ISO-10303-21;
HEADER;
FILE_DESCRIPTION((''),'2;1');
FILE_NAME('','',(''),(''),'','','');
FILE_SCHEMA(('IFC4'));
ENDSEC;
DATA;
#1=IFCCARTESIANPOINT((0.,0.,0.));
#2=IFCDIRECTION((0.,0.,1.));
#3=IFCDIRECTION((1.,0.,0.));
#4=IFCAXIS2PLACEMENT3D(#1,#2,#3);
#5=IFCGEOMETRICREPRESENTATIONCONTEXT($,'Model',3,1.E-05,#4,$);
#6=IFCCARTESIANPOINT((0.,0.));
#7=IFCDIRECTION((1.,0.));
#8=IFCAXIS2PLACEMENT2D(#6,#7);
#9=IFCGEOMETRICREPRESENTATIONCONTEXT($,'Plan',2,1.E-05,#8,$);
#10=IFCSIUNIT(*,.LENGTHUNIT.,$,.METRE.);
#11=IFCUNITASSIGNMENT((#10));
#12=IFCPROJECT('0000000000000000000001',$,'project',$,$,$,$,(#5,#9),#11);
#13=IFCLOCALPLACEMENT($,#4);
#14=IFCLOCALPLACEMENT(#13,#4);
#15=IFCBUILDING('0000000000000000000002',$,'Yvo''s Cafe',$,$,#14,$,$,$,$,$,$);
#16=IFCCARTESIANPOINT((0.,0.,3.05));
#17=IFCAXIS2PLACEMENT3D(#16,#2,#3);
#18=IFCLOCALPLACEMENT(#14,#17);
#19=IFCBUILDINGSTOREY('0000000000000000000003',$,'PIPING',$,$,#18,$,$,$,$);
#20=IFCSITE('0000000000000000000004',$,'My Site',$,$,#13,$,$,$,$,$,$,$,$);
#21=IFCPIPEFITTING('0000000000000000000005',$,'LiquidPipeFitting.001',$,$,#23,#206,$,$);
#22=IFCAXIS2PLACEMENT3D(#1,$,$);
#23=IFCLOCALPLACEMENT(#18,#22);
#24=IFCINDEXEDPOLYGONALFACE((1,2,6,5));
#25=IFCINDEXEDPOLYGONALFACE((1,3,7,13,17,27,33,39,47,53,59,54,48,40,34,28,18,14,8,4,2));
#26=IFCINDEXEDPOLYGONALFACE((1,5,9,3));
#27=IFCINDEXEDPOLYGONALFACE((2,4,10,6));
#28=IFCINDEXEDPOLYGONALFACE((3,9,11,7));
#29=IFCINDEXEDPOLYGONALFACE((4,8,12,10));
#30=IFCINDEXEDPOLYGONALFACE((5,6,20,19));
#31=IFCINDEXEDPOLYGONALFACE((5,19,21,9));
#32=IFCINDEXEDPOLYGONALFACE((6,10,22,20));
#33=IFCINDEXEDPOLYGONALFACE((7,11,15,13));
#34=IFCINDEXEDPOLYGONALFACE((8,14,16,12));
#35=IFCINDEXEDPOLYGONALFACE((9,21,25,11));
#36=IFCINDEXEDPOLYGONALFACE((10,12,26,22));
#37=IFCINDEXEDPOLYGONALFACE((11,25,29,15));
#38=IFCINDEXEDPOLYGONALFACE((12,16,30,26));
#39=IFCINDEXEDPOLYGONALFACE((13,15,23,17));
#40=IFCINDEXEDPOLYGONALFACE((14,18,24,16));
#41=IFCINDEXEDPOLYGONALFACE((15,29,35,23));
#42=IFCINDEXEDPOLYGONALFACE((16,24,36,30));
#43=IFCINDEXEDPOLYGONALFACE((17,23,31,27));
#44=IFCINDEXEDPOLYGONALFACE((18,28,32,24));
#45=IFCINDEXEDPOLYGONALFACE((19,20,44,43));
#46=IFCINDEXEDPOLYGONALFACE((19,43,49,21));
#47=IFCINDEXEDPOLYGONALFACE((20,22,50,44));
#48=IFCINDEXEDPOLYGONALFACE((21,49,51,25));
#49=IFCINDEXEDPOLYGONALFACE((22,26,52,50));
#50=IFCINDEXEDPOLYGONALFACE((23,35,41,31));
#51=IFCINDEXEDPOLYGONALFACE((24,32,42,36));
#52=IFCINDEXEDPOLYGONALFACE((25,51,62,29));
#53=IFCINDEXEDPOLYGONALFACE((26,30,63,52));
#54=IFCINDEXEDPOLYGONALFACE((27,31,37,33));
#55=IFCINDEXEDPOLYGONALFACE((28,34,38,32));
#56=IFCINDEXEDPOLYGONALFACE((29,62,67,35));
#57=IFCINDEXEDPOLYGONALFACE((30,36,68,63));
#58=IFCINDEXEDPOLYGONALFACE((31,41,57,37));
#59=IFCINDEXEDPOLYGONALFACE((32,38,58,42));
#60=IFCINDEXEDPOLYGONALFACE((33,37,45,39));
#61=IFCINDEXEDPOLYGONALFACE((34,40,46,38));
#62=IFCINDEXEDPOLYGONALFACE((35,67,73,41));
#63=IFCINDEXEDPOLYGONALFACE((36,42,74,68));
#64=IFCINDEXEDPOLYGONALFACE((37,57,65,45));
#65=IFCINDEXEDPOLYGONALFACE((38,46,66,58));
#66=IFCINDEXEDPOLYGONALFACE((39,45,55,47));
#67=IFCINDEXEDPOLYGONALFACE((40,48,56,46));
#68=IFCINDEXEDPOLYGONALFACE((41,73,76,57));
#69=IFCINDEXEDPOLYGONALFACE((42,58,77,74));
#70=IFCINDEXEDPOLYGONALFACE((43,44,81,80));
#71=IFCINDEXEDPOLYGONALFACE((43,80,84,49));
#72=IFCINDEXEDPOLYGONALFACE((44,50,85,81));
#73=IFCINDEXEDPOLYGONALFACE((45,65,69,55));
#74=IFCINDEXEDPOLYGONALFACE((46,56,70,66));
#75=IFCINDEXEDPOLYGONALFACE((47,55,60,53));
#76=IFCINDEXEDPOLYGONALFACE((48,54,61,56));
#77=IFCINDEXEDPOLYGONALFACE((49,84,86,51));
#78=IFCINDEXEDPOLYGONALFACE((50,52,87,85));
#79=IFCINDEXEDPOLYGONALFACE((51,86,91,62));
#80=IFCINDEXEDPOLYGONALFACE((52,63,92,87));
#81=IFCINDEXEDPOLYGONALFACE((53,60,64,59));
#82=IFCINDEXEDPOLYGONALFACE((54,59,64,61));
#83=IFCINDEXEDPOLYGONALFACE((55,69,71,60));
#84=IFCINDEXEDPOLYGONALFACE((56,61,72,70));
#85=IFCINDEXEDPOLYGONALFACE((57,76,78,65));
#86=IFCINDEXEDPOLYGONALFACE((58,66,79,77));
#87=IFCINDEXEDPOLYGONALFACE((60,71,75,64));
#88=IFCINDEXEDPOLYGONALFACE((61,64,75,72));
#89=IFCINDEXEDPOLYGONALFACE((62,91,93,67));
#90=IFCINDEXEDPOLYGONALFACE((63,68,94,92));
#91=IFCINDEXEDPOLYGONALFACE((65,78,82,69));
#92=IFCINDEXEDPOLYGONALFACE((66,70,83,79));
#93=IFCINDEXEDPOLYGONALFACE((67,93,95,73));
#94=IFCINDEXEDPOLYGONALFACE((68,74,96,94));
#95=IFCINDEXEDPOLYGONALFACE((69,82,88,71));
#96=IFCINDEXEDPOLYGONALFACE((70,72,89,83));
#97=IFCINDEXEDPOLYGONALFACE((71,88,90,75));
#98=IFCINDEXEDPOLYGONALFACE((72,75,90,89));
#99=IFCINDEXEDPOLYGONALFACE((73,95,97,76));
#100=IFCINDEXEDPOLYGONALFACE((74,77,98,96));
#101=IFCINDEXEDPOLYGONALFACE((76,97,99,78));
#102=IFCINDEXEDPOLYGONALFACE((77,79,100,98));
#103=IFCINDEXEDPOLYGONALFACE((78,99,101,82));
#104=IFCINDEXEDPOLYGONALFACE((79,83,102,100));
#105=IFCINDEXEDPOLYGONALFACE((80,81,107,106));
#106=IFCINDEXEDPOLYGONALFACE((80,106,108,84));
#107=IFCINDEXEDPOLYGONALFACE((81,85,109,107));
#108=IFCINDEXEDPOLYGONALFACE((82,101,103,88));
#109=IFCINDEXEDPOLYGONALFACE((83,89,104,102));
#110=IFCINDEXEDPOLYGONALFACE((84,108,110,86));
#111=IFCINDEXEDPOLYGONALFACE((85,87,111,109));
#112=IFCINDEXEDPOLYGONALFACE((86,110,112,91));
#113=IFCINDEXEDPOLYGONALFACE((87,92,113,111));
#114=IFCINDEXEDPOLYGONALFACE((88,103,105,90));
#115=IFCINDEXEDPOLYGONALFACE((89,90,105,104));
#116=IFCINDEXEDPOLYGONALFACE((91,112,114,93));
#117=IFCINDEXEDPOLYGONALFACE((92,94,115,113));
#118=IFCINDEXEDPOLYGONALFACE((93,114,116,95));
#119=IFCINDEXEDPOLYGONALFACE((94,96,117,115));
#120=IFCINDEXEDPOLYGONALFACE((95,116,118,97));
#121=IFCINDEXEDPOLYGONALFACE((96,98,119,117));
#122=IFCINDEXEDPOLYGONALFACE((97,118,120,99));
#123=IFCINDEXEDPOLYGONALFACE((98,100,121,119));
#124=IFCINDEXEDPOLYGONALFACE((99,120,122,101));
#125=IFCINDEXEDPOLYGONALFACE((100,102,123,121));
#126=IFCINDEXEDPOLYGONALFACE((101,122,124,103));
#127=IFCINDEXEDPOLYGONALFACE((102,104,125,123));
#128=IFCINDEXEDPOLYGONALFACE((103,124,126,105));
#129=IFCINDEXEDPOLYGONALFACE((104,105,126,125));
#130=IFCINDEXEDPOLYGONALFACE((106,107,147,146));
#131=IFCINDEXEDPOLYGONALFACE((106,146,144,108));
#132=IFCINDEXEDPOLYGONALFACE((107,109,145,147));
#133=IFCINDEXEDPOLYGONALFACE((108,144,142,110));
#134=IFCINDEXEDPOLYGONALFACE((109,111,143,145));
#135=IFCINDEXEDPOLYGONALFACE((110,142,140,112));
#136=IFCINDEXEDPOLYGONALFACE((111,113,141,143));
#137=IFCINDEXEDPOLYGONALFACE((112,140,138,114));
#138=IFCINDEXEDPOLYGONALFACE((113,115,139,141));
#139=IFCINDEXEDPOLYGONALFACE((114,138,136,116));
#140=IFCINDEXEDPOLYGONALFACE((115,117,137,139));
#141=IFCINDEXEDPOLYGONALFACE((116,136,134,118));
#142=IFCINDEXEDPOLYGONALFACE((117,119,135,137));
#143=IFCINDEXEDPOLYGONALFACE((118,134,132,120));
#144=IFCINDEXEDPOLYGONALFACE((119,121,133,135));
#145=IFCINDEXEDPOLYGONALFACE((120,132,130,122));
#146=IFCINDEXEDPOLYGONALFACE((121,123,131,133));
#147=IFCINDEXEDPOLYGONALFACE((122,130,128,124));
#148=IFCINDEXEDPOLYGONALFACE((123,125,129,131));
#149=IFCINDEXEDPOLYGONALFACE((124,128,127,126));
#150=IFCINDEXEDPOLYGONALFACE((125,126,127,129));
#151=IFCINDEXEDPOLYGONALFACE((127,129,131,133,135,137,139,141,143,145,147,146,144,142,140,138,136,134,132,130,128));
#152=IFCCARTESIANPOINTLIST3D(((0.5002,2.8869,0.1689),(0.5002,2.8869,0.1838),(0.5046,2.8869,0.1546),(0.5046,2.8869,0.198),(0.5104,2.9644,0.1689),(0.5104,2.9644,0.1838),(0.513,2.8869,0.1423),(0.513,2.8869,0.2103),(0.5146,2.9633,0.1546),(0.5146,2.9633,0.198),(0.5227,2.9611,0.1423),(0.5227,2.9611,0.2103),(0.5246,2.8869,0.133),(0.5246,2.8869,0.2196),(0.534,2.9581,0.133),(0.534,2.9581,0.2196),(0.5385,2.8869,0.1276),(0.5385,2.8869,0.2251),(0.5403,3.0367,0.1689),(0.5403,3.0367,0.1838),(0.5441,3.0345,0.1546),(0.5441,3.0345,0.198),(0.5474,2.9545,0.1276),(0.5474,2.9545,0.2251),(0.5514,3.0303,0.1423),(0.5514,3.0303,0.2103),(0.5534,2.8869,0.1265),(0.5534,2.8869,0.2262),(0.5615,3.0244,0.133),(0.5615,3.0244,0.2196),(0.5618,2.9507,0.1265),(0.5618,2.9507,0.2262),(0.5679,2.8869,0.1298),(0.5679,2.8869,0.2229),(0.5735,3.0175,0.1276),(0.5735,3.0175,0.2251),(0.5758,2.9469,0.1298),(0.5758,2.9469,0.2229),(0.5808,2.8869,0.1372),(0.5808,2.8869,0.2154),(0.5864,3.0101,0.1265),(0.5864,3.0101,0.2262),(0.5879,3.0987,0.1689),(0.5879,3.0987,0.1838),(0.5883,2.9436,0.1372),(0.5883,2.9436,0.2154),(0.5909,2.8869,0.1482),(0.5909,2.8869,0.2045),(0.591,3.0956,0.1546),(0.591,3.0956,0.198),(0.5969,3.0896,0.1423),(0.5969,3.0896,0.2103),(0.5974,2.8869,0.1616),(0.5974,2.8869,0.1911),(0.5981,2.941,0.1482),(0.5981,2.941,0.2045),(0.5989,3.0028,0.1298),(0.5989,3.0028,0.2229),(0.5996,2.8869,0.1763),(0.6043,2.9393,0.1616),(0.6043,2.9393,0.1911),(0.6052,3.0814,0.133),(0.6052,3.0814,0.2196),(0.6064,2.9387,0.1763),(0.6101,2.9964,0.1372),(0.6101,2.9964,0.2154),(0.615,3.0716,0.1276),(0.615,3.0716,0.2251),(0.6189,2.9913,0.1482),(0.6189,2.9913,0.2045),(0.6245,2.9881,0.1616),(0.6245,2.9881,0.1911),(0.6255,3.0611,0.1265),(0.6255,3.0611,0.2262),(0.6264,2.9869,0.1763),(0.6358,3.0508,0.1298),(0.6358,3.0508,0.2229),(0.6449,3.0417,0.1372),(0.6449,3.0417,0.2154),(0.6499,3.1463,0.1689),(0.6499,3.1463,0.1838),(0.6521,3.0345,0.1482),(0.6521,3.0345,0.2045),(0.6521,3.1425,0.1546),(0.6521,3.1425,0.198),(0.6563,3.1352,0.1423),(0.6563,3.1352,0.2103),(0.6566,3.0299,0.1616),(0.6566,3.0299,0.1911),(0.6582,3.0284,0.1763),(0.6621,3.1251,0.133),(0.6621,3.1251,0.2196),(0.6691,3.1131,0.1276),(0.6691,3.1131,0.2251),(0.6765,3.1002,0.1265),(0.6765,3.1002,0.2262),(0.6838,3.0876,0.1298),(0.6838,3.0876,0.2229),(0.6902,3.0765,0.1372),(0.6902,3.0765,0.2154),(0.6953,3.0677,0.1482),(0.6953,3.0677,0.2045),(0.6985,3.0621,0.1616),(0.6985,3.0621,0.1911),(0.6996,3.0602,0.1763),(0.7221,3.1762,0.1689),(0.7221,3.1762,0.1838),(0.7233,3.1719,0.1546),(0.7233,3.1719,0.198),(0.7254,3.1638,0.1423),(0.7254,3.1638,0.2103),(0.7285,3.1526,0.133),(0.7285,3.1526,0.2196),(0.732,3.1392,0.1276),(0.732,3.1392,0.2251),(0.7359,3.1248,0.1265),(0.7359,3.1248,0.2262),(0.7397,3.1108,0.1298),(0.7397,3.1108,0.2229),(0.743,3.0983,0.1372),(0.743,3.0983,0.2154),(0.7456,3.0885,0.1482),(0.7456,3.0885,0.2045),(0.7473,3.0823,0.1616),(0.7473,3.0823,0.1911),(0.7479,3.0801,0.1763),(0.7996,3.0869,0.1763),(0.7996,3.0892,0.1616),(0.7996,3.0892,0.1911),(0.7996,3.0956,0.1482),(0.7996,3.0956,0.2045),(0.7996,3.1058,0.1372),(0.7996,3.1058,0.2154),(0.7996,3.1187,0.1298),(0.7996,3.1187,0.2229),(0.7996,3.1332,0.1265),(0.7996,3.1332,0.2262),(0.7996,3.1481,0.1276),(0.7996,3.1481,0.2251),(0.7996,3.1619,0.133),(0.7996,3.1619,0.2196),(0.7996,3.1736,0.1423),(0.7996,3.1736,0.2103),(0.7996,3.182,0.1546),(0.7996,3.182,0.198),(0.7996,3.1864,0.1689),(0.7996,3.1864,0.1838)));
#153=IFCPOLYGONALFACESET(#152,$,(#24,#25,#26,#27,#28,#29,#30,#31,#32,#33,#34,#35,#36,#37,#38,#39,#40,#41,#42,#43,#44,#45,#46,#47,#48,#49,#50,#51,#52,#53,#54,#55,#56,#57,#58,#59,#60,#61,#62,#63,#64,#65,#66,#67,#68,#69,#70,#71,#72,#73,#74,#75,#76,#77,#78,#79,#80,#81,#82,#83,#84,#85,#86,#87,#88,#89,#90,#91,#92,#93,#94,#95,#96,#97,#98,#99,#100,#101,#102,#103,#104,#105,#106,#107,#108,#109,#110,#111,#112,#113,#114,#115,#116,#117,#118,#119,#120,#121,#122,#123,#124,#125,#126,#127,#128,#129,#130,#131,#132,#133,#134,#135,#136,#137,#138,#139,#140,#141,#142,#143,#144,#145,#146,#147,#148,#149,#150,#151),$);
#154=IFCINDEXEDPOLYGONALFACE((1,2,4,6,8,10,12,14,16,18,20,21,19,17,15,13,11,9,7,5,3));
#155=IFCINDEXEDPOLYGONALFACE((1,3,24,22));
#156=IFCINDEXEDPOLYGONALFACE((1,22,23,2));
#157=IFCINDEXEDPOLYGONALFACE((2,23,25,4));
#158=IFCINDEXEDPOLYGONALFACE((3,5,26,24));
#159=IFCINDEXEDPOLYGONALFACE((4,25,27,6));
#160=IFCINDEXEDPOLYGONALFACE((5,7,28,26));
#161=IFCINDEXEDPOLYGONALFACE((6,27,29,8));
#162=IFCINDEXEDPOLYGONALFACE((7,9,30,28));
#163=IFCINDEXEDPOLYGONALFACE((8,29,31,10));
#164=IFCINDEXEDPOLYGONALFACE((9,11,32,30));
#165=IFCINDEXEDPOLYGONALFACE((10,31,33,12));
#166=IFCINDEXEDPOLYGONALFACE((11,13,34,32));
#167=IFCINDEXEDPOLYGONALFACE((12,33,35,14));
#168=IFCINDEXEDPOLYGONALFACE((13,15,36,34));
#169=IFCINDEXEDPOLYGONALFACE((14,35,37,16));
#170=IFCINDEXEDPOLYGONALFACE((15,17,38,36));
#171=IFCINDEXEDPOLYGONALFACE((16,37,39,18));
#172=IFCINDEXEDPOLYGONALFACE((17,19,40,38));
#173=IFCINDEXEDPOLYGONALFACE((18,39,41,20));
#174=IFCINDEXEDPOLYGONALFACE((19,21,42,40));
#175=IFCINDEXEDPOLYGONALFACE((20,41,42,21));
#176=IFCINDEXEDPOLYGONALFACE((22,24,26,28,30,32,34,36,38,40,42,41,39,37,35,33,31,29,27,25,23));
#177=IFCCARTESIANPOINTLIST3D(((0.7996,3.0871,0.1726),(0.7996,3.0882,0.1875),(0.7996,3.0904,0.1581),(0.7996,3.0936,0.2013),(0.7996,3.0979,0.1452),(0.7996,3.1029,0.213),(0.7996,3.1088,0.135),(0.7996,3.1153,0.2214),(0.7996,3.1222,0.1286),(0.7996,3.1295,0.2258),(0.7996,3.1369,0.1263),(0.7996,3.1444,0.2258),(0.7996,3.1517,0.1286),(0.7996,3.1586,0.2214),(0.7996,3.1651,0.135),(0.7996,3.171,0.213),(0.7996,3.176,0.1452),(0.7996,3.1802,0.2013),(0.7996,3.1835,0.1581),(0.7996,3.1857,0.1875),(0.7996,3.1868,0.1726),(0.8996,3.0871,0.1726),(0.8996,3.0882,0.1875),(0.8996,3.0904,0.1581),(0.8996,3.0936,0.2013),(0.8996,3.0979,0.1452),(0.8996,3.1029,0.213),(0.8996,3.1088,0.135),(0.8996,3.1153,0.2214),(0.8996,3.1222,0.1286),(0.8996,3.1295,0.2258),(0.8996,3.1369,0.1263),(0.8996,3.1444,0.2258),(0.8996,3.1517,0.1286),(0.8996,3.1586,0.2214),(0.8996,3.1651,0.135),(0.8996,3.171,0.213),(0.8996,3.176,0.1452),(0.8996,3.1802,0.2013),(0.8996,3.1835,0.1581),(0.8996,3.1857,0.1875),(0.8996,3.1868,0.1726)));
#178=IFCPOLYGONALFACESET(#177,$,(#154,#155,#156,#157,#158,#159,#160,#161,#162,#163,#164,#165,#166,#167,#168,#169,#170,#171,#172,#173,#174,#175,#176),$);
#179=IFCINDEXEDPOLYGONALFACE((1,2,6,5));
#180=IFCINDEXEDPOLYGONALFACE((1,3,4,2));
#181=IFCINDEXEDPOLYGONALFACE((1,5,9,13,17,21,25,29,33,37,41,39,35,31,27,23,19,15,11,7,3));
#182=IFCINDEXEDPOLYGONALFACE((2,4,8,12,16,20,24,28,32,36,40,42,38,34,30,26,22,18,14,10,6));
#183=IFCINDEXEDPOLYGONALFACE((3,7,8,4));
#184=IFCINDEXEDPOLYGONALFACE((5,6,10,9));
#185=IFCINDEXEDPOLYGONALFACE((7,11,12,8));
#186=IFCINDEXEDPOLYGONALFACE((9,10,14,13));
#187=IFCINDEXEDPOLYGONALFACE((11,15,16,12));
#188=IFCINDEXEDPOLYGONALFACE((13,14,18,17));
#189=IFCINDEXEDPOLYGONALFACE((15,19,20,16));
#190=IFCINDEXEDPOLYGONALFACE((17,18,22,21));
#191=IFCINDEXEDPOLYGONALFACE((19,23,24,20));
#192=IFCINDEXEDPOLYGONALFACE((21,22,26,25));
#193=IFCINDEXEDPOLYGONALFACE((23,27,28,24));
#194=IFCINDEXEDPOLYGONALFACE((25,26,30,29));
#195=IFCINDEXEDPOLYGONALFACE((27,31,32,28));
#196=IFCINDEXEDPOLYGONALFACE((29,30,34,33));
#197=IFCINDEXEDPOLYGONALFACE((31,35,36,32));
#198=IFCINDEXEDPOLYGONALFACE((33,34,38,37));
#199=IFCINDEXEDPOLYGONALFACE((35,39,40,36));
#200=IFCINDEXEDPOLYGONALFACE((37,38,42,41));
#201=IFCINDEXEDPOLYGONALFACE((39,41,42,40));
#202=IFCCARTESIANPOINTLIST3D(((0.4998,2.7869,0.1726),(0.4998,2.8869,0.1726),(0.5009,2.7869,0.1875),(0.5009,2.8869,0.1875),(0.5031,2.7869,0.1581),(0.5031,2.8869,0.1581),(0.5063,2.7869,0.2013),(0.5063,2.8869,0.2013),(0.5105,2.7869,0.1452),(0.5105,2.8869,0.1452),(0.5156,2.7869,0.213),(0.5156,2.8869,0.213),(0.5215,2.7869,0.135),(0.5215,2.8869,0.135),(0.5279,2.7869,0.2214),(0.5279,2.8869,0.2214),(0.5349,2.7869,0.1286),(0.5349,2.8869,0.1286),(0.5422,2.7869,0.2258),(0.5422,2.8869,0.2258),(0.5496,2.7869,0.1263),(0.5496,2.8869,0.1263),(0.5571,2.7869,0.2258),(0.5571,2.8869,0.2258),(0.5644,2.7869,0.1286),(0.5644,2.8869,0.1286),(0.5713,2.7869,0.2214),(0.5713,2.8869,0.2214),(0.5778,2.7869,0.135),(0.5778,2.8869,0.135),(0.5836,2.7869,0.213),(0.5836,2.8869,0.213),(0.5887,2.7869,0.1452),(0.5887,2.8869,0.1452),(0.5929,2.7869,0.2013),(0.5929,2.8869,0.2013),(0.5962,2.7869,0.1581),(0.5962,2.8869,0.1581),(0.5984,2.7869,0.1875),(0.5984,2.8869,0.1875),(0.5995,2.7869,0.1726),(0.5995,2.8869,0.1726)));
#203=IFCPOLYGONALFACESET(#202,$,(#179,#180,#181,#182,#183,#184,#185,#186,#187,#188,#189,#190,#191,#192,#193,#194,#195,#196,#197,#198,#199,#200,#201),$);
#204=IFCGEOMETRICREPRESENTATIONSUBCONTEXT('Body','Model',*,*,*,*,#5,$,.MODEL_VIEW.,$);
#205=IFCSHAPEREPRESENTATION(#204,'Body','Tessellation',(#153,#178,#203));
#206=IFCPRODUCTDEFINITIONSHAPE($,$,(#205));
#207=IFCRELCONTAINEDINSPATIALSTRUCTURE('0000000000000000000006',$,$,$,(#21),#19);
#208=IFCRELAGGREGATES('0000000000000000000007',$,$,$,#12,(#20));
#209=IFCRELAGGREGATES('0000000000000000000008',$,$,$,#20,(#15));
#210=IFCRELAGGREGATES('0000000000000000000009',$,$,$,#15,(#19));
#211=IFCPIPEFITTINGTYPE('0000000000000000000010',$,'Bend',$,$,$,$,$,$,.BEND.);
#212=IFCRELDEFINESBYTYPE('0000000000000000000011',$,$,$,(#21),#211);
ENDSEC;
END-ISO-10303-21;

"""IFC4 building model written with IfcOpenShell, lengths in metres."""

from ifc_helpers import new_model, entity, si_unit, frame, origin_with_axes, origin_2d_with_axis, place, context, subcontext, project, spatial, line, indexed_curve, circle, outline, extrude, source, transform, mapped, type_object, type_shapes, element, save


model = new_model("IFC4")

# Units and contexts
model_context = context("Model", 3, precision=1e-05, world=origin_with_axes())
plan_context = context("Plan", 2, precision=1e-05, world=origin_2d_with_axis())
body_context = subcontext(model_context, "Body", "Model", "MODEL_VIEW")
ifc_project = project(units=[si_unit("LENGTHUNIT", "METRE")], contexts=[model_context, plan_context])

# Site, building, storey
site_placement = place(None, origin_with_axes())
site = spatial("IfcSite", under=ifc_project, at=site_placement, Name="My Site")
building_placement = place(site_placement, origin_with_axes())
building = spatial("IfcBuilding", under=site, at=building_placement, Name="Yvo's Cafe")
storey_placement = place(building_placement, frame((0.0, 0.0, 3.05), z_axis=(0.0, 0.0, 1.0), x_axis=(1.0, 0.0, 0.0)))
storey = spatial("IfcBuildingStorey", under=building, at=storey_placement, Name="PIPING")

# Shared definitions
pipe_fitting_type_1 = type_object("IfcPipeFittingType", Name="Bend", PredefinedType="BEND")
shared_shape_1 = source(origin_with_axes(), body_context, "Body", "SolidModel", [
    entity("IfcSweptDiskSolid", entity("IfcIndexedPolyCurve", entity("IfcCartesianPointList3D", [[0.0, 0.0, -0.1], [0.0, -0.0732, -0.2768], [0.0, -0.25, -0.35]]), [entity("IfcArcIndex", [1, 2, 3])]), 0.05),
    extrude(circle(Radius=0.05), origin_with_axes(), (0.0, 0.0, -1.0), 0.1),
    extrude(circle(Radius=0.05), frame((0.0, -0.25, -0.35), z_axis=(0.0, -1.0, 0.0), x_axis=(1.0, 0.0, 0.0)), (0.0, 0.0, 1.0), 0.1),
])
type_shapes(pipe_fitting_type_1, [shared_shape_1])

# Pipe fitting, opening
pipe_fitting_1_placement = place(storey_placement, frame((0.8996, 3.1369, 0.1763), z_axis=(1.0, 0.0, 0.0), x_axis=(0.0, 0.0, -1.0)))
pipe_fitting_1 = element("IfcPipeFitting", 1, at=pipe_fitting_1_placement, inside=storey, type_object=pipe_fitting_type_1, Name="LiquidPipeFitting.001", context=body_context, shape_type="MappedRepresentation", body=[
    mapped(shared_shape_1, transform((0.0, 0.0, 0.0), x_axis=(1.0, 0.0, 0.0), y_axis=(0.0, 1.0, 0.0), z_axis=(0.0, 0.0, 1.0), scale=1.0)),
])
opening_placement = place(pipe_fitting_1_placement, frame((3.2263, -3.1369, -0.8996), z_axis=(-1.0, 0.0, 0.0), x_axis=(0.0, 0.0, 1.0)))
element("IfcOpeningElement", 2, at=opening_placement, cuts=pipe_fitting_1, PredefinedType="OPENING", context=body_context, shape_type="SweptSolid", body=[
    extrude(outline(indexed_curve([(0.0, 0.0), (0.5, 0.0), (0.5, 0.5), (0.0, 0.5)], segments=[line(1, 2, 3, 4, 1)])), origin_with_axes(), (0.0, 0.0, 1.0), 0.5),
])

save(model, "model.ifc")
